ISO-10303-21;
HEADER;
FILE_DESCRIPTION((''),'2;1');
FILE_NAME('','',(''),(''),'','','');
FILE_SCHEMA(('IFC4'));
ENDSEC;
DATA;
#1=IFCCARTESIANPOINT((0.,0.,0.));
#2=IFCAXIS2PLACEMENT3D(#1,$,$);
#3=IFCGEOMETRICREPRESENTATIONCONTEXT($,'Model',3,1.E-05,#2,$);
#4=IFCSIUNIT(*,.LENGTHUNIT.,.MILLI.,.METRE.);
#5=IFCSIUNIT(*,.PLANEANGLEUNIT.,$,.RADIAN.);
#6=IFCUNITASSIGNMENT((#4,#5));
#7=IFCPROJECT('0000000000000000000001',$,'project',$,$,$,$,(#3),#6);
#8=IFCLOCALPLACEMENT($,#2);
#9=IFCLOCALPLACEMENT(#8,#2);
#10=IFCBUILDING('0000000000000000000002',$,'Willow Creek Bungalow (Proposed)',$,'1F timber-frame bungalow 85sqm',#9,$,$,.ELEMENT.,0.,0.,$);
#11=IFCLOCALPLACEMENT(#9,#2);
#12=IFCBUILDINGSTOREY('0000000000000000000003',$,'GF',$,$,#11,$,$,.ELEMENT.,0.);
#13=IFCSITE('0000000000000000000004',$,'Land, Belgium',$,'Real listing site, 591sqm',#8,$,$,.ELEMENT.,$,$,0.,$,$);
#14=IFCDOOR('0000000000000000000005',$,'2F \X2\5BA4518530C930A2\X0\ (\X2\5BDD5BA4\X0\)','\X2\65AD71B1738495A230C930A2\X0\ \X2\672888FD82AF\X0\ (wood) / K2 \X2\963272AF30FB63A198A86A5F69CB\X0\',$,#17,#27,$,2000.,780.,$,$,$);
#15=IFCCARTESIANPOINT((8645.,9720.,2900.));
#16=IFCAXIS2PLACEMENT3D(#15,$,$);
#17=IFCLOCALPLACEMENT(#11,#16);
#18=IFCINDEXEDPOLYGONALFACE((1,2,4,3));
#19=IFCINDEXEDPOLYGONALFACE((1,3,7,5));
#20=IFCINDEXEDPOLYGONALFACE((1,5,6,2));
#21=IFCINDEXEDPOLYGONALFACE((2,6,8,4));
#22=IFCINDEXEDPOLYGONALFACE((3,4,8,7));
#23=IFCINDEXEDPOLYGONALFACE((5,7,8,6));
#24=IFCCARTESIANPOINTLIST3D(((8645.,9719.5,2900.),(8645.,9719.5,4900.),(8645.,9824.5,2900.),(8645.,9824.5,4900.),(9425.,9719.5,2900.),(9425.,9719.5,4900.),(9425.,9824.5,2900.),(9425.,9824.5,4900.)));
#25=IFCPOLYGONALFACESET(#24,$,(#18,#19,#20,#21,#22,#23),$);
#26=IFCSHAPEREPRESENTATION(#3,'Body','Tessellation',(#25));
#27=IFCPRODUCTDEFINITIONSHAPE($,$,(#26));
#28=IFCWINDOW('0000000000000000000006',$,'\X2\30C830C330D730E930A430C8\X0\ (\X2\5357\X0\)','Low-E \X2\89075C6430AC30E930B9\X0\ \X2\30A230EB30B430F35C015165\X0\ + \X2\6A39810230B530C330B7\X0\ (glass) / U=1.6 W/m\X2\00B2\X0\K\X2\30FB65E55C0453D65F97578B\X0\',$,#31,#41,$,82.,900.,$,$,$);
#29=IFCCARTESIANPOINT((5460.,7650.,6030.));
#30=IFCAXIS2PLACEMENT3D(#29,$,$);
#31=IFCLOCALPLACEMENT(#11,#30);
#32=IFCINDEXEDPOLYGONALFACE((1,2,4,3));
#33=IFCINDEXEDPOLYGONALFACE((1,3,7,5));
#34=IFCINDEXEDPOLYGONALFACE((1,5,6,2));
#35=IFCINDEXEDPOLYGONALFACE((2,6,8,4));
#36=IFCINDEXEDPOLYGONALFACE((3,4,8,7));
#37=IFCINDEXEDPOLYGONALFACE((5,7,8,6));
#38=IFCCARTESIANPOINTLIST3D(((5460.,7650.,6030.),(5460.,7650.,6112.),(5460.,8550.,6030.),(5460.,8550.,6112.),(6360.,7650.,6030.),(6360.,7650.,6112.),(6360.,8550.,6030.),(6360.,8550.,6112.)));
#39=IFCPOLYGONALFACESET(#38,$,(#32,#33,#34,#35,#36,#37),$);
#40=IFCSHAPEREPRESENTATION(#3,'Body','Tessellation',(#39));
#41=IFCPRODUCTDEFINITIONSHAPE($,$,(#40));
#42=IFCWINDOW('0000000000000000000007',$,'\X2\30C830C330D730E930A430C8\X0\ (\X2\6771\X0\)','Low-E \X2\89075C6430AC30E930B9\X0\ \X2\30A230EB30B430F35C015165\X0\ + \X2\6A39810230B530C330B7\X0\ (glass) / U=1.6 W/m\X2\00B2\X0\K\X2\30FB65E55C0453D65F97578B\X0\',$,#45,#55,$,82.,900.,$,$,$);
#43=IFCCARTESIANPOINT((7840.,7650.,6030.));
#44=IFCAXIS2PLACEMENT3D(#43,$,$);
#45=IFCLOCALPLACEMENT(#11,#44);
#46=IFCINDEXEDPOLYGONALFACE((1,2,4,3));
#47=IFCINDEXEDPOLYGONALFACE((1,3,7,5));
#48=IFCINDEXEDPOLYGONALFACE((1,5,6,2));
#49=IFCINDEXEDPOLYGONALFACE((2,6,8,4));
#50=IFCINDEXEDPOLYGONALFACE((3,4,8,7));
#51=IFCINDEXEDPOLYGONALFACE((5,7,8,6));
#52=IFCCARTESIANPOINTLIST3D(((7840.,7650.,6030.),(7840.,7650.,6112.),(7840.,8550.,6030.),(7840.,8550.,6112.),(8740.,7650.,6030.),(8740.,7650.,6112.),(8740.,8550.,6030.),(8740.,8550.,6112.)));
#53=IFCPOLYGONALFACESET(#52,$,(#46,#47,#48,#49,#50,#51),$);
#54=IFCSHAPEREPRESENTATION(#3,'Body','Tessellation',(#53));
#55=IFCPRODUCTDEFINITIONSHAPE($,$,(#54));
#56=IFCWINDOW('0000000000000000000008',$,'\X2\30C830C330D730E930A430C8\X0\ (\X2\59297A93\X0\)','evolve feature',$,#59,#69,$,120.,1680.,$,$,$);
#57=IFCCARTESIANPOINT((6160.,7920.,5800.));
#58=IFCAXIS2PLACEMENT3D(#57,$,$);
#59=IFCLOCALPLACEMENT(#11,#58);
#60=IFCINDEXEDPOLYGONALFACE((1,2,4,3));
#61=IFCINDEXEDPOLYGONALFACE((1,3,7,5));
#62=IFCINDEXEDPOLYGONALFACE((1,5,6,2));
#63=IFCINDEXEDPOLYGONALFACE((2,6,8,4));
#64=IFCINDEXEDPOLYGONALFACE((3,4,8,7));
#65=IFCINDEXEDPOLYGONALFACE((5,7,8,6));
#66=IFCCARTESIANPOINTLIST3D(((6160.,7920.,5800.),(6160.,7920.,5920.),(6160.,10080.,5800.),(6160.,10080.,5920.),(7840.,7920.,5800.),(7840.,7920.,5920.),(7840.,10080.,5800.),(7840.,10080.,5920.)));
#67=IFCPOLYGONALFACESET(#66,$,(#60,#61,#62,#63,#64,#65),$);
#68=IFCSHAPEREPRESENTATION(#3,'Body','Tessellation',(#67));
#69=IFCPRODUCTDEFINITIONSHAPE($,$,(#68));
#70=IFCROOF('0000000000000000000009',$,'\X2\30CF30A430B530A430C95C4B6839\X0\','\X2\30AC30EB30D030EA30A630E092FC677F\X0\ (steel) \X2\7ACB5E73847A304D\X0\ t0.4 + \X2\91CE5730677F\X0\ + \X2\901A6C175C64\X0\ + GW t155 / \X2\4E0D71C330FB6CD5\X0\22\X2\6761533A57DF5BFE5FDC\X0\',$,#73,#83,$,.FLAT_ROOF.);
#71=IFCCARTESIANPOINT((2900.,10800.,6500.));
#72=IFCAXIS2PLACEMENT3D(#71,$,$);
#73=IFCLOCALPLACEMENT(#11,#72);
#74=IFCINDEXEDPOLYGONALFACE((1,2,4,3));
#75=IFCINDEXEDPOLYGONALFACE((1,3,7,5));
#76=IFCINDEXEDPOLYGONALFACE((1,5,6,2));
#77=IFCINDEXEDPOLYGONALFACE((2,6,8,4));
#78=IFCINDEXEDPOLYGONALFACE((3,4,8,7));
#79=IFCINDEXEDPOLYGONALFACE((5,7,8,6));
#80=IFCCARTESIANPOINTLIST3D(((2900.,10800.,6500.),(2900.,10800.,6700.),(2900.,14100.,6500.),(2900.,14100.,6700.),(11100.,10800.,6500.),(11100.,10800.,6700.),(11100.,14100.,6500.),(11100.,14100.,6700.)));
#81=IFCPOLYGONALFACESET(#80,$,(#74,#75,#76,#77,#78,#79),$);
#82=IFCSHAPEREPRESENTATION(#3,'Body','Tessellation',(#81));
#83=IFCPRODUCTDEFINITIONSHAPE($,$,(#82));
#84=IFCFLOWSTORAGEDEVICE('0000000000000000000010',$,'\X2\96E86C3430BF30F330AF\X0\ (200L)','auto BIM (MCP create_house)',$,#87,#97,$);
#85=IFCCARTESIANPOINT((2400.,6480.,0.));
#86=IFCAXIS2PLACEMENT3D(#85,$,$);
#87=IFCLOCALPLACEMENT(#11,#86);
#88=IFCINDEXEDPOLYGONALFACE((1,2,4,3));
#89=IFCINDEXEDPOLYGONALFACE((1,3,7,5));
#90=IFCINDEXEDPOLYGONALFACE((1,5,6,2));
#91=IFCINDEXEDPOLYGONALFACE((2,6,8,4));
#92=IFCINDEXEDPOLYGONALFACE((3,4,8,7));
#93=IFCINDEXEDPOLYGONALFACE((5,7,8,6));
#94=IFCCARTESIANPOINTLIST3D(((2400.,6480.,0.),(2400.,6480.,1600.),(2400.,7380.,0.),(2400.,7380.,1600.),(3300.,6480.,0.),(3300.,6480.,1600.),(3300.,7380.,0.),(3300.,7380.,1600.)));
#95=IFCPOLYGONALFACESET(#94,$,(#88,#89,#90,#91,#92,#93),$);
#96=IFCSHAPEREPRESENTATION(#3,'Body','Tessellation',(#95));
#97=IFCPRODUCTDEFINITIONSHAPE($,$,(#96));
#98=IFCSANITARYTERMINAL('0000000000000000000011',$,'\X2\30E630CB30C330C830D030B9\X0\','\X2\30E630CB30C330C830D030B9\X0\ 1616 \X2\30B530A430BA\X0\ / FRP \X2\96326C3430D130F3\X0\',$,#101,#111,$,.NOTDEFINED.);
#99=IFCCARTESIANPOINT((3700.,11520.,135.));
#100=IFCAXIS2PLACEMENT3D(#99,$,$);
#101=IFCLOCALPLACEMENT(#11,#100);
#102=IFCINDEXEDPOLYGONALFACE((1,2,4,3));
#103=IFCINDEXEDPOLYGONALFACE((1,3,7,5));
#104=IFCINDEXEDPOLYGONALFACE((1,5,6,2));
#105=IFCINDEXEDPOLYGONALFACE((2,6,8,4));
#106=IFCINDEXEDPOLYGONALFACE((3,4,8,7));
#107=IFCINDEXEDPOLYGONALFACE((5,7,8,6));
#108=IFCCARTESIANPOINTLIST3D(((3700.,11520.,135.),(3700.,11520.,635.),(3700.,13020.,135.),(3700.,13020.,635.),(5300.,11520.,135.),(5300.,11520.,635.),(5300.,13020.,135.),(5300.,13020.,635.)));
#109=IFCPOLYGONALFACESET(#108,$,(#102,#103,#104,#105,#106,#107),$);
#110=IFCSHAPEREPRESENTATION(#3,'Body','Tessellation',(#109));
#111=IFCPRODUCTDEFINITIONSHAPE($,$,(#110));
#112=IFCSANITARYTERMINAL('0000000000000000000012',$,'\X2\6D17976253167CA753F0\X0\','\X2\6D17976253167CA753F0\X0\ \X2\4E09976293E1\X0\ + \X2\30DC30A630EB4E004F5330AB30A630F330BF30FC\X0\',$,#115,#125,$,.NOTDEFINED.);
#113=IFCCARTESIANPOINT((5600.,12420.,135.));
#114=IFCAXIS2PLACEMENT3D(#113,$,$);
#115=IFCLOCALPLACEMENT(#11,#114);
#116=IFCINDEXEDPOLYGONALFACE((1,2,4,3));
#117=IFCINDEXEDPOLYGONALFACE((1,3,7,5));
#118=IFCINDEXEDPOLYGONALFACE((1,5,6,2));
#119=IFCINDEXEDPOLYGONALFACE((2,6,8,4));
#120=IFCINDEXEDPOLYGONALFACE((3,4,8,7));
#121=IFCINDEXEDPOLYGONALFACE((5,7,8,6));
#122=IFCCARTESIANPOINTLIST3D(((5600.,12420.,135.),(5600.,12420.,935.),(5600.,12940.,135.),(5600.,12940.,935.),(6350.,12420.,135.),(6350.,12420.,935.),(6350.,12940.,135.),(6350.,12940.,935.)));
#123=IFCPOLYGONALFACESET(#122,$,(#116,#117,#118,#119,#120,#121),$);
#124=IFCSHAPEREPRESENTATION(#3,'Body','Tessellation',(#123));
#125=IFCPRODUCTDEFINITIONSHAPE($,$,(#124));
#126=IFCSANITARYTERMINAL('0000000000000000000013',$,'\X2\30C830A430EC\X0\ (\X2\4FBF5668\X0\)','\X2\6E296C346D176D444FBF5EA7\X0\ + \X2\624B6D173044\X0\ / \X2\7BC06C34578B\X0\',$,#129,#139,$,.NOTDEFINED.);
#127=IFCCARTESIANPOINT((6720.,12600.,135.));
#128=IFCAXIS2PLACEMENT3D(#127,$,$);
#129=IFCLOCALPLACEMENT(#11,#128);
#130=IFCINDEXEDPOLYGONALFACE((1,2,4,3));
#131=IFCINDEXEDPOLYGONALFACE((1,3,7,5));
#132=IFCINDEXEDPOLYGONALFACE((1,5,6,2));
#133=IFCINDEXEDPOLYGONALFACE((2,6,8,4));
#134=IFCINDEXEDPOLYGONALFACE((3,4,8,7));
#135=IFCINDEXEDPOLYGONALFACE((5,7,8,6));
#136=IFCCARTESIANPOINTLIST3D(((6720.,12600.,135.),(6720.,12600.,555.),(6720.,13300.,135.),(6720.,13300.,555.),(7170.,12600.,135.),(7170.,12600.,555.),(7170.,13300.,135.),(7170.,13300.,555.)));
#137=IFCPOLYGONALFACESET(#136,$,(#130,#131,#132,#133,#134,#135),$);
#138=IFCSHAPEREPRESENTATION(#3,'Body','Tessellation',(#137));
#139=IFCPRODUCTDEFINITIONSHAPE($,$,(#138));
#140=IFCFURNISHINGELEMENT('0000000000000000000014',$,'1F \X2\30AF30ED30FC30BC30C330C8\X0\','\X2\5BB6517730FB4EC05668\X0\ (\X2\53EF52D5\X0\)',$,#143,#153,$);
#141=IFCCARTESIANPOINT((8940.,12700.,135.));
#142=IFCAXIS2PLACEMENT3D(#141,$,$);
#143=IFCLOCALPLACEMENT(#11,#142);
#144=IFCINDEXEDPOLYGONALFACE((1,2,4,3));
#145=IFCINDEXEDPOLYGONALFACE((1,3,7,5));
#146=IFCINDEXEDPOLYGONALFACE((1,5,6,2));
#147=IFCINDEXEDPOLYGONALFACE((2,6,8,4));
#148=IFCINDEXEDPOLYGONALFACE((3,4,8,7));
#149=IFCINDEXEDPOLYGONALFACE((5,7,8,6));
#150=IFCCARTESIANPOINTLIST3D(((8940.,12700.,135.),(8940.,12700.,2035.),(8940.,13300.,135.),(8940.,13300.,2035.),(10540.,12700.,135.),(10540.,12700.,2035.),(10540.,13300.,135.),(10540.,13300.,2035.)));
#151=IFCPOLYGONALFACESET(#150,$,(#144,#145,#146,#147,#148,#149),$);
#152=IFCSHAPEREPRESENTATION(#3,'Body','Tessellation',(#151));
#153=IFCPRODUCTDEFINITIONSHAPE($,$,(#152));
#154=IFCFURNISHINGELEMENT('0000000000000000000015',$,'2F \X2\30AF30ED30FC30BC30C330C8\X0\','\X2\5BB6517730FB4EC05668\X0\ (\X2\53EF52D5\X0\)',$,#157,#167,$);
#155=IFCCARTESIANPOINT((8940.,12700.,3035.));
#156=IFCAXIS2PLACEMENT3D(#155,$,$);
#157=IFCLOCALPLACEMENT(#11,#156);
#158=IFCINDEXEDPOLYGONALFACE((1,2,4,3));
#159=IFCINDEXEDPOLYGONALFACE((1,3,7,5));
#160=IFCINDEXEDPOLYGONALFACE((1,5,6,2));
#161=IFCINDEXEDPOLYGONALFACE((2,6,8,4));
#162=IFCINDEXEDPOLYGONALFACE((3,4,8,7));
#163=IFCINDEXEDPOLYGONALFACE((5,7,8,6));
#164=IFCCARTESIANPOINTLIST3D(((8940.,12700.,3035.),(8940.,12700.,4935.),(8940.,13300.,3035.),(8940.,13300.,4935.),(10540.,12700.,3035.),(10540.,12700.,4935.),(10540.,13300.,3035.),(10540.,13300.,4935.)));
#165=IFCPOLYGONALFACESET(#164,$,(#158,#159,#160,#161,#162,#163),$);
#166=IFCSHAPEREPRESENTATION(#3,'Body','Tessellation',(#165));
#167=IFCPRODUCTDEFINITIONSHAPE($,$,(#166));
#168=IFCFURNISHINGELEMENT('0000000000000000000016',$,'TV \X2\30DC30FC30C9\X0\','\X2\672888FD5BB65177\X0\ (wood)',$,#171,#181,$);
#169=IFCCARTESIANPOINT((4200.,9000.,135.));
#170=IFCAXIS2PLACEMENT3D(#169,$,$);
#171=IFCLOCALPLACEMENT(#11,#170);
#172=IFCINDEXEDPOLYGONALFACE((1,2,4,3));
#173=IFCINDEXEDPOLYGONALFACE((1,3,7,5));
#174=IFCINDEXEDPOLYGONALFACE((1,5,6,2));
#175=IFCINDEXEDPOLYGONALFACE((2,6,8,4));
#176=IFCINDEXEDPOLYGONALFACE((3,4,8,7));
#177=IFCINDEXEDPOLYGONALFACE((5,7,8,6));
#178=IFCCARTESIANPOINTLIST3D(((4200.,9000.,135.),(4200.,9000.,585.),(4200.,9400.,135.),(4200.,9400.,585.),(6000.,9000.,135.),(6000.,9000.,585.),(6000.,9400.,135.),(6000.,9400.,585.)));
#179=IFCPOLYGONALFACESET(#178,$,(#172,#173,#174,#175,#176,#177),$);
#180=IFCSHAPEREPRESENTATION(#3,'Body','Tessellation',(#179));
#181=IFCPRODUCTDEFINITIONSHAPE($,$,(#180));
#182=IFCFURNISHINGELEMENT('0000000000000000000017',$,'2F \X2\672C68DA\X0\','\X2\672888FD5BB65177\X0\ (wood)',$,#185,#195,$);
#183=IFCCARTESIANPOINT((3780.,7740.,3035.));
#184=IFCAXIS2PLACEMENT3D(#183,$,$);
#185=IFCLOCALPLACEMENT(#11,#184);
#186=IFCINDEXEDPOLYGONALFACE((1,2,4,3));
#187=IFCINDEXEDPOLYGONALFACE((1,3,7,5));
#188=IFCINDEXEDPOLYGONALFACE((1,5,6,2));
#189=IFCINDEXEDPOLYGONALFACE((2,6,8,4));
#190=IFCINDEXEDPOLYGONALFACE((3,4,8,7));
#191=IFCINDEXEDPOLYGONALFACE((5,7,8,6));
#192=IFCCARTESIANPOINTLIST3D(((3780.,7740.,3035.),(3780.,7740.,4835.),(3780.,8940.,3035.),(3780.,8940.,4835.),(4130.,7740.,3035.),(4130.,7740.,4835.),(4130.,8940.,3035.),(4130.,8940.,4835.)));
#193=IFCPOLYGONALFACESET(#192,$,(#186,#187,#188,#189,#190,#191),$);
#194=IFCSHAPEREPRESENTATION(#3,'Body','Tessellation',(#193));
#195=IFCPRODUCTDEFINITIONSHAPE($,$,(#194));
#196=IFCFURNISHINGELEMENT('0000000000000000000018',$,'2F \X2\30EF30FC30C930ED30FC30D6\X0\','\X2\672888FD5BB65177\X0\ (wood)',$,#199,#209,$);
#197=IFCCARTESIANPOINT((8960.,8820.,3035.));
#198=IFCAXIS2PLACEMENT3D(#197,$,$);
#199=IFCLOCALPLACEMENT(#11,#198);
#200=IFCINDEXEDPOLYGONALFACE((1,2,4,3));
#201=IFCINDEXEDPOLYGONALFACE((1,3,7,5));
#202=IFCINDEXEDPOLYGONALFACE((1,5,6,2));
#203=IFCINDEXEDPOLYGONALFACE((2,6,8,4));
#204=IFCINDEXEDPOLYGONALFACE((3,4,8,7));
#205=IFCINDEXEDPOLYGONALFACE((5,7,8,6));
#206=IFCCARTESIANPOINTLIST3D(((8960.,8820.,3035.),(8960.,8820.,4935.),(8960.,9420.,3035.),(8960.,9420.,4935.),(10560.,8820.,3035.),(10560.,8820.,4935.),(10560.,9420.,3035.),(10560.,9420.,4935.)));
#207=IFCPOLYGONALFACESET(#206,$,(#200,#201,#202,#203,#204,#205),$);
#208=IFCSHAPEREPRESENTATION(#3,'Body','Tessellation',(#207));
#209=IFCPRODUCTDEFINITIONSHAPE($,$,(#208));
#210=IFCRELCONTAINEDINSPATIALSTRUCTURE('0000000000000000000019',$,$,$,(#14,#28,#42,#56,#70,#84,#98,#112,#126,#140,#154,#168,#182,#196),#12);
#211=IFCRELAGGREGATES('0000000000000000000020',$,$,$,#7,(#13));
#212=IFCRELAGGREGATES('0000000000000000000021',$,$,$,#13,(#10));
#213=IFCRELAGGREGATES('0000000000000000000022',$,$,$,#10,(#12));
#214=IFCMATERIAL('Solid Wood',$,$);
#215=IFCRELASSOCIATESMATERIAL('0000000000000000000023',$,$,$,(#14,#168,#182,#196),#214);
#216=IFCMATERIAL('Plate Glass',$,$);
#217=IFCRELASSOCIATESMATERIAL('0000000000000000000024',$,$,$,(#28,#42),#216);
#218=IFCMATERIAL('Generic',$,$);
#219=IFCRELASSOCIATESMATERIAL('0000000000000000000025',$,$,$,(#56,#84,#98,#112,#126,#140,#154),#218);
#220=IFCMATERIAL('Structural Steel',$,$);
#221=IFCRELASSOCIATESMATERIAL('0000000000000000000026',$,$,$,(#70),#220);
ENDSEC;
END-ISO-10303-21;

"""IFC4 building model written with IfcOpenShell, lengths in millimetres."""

from ifc_helpers import new_model, si_unit, frame, frame_2d, origin, place, context, project, spatial, rectangle, extrude, material, element, save


model = new_model("IFC4")

# Units and contexts
model_context = context("Model", 3, precision=1e-05, world=origin())
ifc_project = project(units=[si_unit("LENGTHUNIT", "METRE", prefix="MILLI"), si_unit("PLANEANGLEUNIT", "RADIAN")], contexts=[model_context])

# Site, building, storey
site_placement = place(None, origin())
site = spatial("IfcSite", under=ifc_project, at=site_placement, Name="Land, Belgium", ObjectType="Real listing site, 591sqm", CompositionType="ELEMENT", RefElevation=0.0)
building_placement = place(site_placement, origin())
building = spatial("IfcBuilding", under=site, at=building_placement, Name="Willow Creek Bungalow (Proposed)", ObjectType="1F timber-frame bungalow 85sqm", CompositionType="ELEMENT", ElevationOfRefHeight=0.0, ElevationOfTerrain=0.0)
storey_placement = place(building_placement, origin())
storey = spatial("IfcBuildingStorey", under=building, at=storey_placement, Name="GF", CompositionType="ELEMENT", Elevation=0.0)

# Shared definitions
ifc_material_1 = material(Name="Solid Wood")
ifc_material_2 = material(Name="Plate Glass")

# Door
door_1_placement = place(storey_placement, frame((8645.0, 9720.0, 2900.0)))
element("IfcDoor", 1, at=door_1_placement, inside=storey, material=ifc_material_1, Name="2F 室内ドア (寝室)", Description="断熱玄関ドア 木製芯 (wood) / K2 防犯・採風機構", OverallHeight=2000.0, OverallWidth=780.0, context=model_context, shape_type="SweptSolid", body=[
    extrude(rectangle(XDim=780.0, YDim=105.0, at=frame_2d((390.0, 52.0))), frame((8645.0, 9720.0, 2900.0)), (0.0, 0.0, 1.0), 2000.0),
])

# Windows
window_1_placement = place(storey_placement, frame((5460.0, 7650.0, 6030.0)))
element("IfcWindow", 2, at=window_1_placement, inside=storey, material=ifc_material_2, Name="トップライト (南)", Description="Low-E 複層ガラス アルゴン封入 + 樹脂サッシ (glass) / U=1.6 W/m²K・日射取得型", OverallHeight=82.0, OverallWidth=900.0, context=model_context, shape_type="SweptSolid", body=[
    extrude(rectangle(XDim=900.0, YDim=900.0, at=frame_2d((450.0, 450.0))), frame((5460.0, 7650.0, 6030.0)), (0.0, 0.0, 1.0), 82.0),
])
window_2_placement = place(storey_placement, frame((7840.0, 7650.0, 6030.0)))
element("IfcWindow", 3, at=window_2_placement, inside=storey, material=ifc_material_2, Name="トップライト (東)", Description="Low-E 複層ガラス アルゴン封入 + 樹脂サッシ (glass) / U=1.6 W/m²K・日射取得型", OverallHeight=82.0, OverallWidth=900.0, context=model_context, shape_type="SweptSolid", body=[
    extrude(rectangle(XDim=900.0, YDim=900.0, at=frame_2d((450.0, 450.0))), frame((7840.0, 7650.0, 6030.0)), (0.0, 0.0, 1.0), 82.0),
])
ifc_material_3 = material(Name="Generic")
window_3_placement = place(storey_placement, frame((6160.0, 7920.0, 5800.0)))
element("IfcWindow", 4, at=window_3_placement, inside=storey, material=ifc_material_3, Name="トップライト (天窓)", Description="evolve feature", OverallHeight=120.0, OverallWidth=1680.0, context=model_context, shape_type="SweptSolid", body=[
    extrude(rectangle(XDim=1680.0, YDim=2160.0, at=frame_2d((840.0, 1080.0))), frame((6160.0, 7920.0, 5800.0)), (0.0, 0.0, 1.0), 120.0),
])

# Roof
ifc_material_4 = material(Name="Structural Steel")
roof_placement = place(storey_placement, frame((2900.0, 10800.0, 6500.0)))
element("IfcRoof", 5, at=roof_placement, inside=storey, material=ifc_material_4, Name="ハイサイド屋根", Description="ガルバリウム鋼板 (steel) 立平葺き t0.4 + 野地板 + 通気層 + GW t155 / 不燃・法22条区域対応", PredefinedType="FLAT_ROOF", context=model_context, shape_type="SweptSolid", body=[
    extrude(rectangle(XDim=8200.0, YDim=3300.0, at=frame_2d((4100.0, 1650.0))), frame((2900.0, 10800.0, 6500.0)), (0.0, 0.0, 1.0), 200.0),
])

# Flow storage device
flow_storage_device_placement = place(storey_placement, frame((2400.0, 6480.0, 0.0)))
element("IfcFlowStorageDevice", 6, at=flow_storage_device_placement, inside=storey, material=ifc_material_3, Name="雨水タンク (200L)", Description="auto BIM (MCP create_house)", context=model_context, shape_type="SweptSolid", body=[
    extrude(rectangle(XDim=900.0, YDim=900.0, at=frame_2d((450.0, 450.0))), frame((2400.0, 6480.0, 0.0)), (0.0, 0.0, 1.0), 1600.0),
])

# Sanitary terminals
sanitary_terminal_1_placement = place(storey_placement, frame((3700.0, 11520.0, 135.0)))
element("IfcSanitaryTerminal", 7, at=sanitary_terminal_1_placement, inside=storey, material=ifc_material_3, Name="ユニットバス", Description="ユニットバス 1616 サイズ / FRP 防水パン", PredefinedType="NOTDEFINED", context=model_context, shape_type="SweptSolid", body=[
    extrude(rectangle(XDim=1600.0, YDim=1500.0, at=frame_2d((800.0, 750.0))), frame((3700.0, 11520.0, 135.0)), (0.0, 0.0, 1.0), 500.0),
])
sanitary_terminal_2_placement = place(storey_placement, frame((5600.0, 12420.0, 135.0)))
element("IfcSanitaryTerminal", 8, at=sanitary_terminal_2_placement, inside=storey, material=ifc_material_3, Name="洗面化粧台", Description="洗面化粧台 三面鏡 + ボウル一体カウンター", PredefinedType="NOTDEFINED", context=model_context, shape_type="SweptSolid", body=[
    extrude(rectangle(XDim=750.0, YDim=520.0, at=frame_2d((375.0, 260.0))), frame((5600.0, 12420.0, 135.0)), (0.0, 0.0, 1.0), 800.0),
])
sanitary_terminal_3_placement = place(storey_placement, frame((6720.0, 12600.0, 135.0)))
element("IfcSanitaryTerminal", 9, at=sanitary_terminal_3_placement, inside=storey, material=ifc_material_3, Name="トイレ (便器)", Description="温水洗浄便座 + 手洗い / 節水型", PredefinedType="NOTDEFINED", context=model_context, shape_type="SweptSolid", body=[
    extrude(rectangle(XDim=450.0, YDim=700.0, at=frame_2d((225.0, 350.0))), frame((6720.0, 12600.0, 135.0)), (0.0, 0.0, 1.0), 420.0),
])

# Furnishing elements
furnishing_1_placement = place(storey_placement, frame((8940.0, 12700.0, 135.0)))
element("IfcFurnishingElement", 10, at=furnishing_1_placement, inside=storey, material=ifc_material_3, Name="1F クローゼット", Description="家具・什器 (可動)", context=model_context, shape_type="SweptSolid", body=[
    extrude(rectangle(XDim=1600.0, YDim=600.0, at=frame_2d((800.0, 300.0))), frame((8940.0, 12700.0, 135.0)), (0.0, 0.0, 1.0), 1900.0),
])
furnishing_2_placement = place(storey_placement, frame((8940.0, 12700.0, 3035.0)))
element("IfcFurnishingElement", 11, at=furnishing_2_placement, inside=storey, material=ifc_material_3, Name="2F クローゼット", Description="家具・什器 (可動)", context=model_context, shape_type="SweptSolid", body=[
    extrude(rectangle(XDim=1600.0, YDim=600.0, at=frame_2d((800.0, 300.0))), frame((8940.0, 12700.0, 3035.0)), (0.0, 0.0, 1.0), 1900.0),
])
furnishing_3_placement = place(storey_placement, frame((4200.0, 9000.0, 135.0)))
element("IfcFurnishingElement", 12, at=furnishing_3_placement, inside=storey, material=ifc_material_1, Name="TV ボード", Description="木製家具 (wood)", context=model_context, shape_type="SweptSolid", body=[
    extrude(rectangle(XDim=1800.0, YDim=400.0, at=frame_2d((900.0, 200.0))), frame((4200.0, 9000.0, 135.0)), (0.0, 0.0, 1.0), 450.0),
])
furnishing_4_placement = place(storey_placement, frame((3780.0, 7740.0, 3035.0)))
element("IfcFurnishingElement", 13, at=furnishing_4_placement, inside=storey, material=ifc_material_1, Name="2F 本棚", Description="木製家具 (wood)", context=model_context, shape_type="SweptSolid", body=[
    extrude(rectangle(XDim=350.0, YDim=1200.0, at=frame_2d((175.0, 600.0))), frame((3780.0, 7740.0, 3035.0)), (0.0, 0.0, 1.0), 1800.0),
])
furnishing_5_placement = place(storey_placement, frame((8960.0, 8820.0, 3035.0)))
element("IfcFurnishingElement", 14, at=furnishing_5_placement, inside=storey, material=ifc_material_1, Name="2F ワードローブ", Description="木製家具 (wood)", context=model_context, shape_type="SweptSolid", body=[
    extrude(rectangle(XDim=1600.0, YDim=600.0, at=frame_2d((800.0, 300.0))), frame((8960.0, 8820.0, 3035.0)), (0.0, 0.0, 1.0), 1900.0),
])

save(model, "model.ifc")
